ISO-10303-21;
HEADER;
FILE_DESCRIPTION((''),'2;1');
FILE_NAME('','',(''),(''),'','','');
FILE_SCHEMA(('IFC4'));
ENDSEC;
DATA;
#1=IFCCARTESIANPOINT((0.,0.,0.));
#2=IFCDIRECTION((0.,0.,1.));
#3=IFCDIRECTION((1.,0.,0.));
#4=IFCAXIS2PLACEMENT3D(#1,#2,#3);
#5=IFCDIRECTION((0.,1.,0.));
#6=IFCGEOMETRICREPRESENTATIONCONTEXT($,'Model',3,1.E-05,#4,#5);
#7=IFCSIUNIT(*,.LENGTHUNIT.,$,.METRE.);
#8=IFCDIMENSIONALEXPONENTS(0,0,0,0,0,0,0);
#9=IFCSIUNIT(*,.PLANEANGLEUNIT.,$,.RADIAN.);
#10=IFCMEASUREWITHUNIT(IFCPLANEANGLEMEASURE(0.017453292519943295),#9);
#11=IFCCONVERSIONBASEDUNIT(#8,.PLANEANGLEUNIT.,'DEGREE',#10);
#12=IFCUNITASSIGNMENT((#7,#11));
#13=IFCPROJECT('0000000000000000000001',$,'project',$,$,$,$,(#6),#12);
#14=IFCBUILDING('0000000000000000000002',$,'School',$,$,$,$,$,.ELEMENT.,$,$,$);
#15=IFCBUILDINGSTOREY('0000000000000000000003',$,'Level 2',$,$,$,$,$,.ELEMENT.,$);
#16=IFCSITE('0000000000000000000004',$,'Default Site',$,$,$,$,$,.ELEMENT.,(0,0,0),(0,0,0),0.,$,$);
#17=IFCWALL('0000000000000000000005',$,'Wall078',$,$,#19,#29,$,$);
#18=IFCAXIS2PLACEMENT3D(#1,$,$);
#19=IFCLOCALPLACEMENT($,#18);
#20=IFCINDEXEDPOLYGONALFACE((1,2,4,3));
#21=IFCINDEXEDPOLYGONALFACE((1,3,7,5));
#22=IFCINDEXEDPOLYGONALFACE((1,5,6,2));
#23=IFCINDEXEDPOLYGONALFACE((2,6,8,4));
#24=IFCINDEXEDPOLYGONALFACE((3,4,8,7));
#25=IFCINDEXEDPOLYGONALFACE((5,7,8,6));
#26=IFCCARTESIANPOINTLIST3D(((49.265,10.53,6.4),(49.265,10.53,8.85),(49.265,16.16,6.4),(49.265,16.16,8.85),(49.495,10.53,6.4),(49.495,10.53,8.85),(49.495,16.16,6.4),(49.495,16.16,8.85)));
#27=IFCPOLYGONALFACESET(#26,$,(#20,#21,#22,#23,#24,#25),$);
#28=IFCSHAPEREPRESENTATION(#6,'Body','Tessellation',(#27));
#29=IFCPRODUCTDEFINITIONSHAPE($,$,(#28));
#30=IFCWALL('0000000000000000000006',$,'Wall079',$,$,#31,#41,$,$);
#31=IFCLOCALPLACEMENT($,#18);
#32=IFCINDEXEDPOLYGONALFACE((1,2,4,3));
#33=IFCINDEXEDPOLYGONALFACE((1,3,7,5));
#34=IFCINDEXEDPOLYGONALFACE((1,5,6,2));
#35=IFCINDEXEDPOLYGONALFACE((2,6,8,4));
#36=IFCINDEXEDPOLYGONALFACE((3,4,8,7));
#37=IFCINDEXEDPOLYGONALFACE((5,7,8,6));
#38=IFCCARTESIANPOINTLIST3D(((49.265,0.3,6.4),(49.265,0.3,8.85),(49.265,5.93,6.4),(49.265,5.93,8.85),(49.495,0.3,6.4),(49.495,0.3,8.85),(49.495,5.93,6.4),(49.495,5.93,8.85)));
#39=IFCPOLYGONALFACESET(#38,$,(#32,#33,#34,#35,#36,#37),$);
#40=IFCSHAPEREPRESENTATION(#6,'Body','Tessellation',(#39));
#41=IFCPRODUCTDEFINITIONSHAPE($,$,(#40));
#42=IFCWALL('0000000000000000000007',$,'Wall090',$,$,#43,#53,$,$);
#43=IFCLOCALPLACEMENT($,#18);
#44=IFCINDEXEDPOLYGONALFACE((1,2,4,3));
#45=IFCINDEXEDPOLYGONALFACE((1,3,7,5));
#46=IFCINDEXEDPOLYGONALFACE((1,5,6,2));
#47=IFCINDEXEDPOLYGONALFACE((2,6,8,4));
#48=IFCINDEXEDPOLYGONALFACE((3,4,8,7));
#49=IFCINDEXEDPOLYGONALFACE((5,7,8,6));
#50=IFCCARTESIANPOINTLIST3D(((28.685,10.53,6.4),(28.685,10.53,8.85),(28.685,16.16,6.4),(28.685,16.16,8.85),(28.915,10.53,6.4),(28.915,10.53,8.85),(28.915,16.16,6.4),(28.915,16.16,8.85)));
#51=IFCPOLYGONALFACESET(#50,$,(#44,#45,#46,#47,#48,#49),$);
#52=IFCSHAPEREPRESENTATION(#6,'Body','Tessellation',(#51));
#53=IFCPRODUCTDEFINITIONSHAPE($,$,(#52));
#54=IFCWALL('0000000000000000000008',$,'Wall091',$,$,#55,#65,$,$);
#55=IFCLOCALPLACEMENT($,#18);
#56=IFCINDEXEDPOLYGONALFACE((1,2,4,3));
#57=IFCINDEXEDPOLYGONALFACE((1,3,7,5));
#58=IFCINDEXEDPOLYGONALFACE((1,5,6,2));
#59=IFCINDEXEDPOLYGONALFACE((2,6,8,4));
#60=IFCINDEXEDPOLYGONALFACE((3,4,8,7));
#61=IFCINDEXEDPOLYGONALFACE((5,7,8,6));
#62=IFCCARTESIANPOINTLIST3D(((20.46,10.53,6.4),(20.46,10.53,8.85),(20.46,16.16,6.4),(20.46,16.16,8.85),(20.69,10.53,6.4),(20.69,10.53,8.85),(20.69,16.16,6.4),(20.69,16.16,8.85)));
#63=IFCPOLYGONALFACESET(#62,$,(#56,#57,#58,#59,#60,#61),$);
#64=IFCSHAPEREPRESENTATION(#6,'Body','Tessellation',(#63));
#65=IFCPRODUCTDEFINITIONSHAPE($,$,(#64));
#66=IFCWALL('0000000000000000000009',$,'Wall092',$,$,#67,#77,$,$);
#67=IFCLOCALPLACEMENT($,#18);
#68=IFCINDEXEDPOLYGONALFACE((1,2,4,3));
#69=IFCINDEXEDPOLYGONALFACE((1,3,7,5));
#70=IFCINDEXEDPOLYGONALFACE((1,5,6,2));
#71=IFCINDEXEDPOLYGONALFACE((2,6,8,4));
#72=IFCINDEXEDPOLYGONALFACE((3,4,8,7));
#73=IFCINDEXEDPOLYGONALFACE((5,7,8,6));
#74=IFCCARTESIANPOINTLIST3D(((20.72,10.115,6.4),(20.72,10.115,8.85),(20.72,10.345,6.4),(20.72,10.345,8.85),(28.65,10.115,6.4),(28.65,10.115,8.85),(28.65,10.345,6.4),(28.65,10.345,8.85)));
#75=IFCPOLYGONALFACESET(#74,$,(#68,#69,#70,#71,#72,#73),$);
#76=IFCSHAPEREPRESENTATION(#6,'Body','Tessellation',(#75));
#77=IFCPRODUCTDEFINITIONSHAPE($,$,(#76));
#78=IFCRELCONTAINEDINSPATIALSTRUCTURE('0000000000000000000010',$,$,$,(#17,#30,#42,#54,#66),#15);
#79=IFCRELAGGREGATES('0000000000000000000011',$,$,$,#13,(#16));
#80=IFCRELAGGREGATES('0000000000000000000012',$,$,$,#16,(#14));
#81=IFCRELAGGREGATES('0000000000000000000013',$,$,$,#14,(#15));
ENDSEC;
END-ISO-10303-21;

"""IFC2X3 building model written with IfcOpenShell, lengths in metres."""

from ifc_helpers import new_model, entity, si_unit, converted_unit, direction, frame, frame_2d, origin_with_axes, place, context, project, spatial, rectangle, extrude, element, save


model = new_model("IFC2X3")

# Units and contexts
model_context = context("Model", 3, precision=1e-05, world=origin_with_axes(), true_north=direction((0.0, 1.0, 0.0)))
ifc_project = project(units=[si_unit("LENGTHUNIT", "METRE"), converted_unit("PLANEANGLEUNIT", "DEGREE", entity("IfcPlaneAngleMeasure", 0.017453292519943295), si_unit("PLANEANGLEUNIT", "RADIAN"), dimensions=[0, 0, 0, 0, 0, 0, 0])], contexts=[model_context])

# Site, building, storey
site = spatial("IfcSite", under=ifc_project, Name="Default Site", CompositionType="ELEMENT", RefLatitude=(0, 0, 0), RefLongitude=(0, 0, 0), RefElevation=0.0)
building = spatial("IfcBuilding", under=site, Name="School", CompositionType="ELEMENT")
storey = spatial("IfcBuildingStorey", under=building, Name="Level 2", CompositionType="ELEMENT")

# Shared definitions
placement = place(None, origin_with_axes())

# Walls
element("IfcWall", 1, at=placement, inside=storey, Name="Wall078", context=model_context, shape_type="SweptSolid", body=[
    extrude(rectangle(XDim=5.63, YDim=0.23, at=frame_2d((0.0, 0.0), x_axis=(0.0, 1.0, 0.0))), frame((49.38, 13.345, 6.4), z_axis=(0.0, 0.0, 1.0), x_axis=(1.0, 0.0, 0.0)), (0.0, 0.0, 1.0), 2.45),
])
element("IfcWall", 2, at=placement, inside=storey, Name="Wall079", context=model_context, shape_type="SweptSolid", body=[
    extrude(rectangle(XDim=5.63, YDim=0.23, at=frame_2d((0.0, 0.0), x_axis=(0.0, 1.0, 0.0))), frame((49.38, 3.115, 6.4), z_axis=(0.0, 0.0, 1.0), x_axis=(1.0, 0.0, 0.0)), (0.0, 0.0, 1.0), 2.45),
])
element("IfcWall", 3, at=placement, inside=storey, Name="Wall090", context=model_context, shape_type="SweptSolid", body=[
    extrude(rectangle(XDim=5.63, YDim=0.23, at=frame_2d((0.0, 0.0), x_axis=(0.0, 1.0, 0.0))), frame((28.8, 13.345, 6.4), z_axis=(0.0, 0.0, 1.0), x_axis=(1.0, 0.0, 0.0)), (0.0, 0.0, 1.0), 2.45),
])
element("IfcWall", 4, at=placement, inside=storey, Name="Wall091", context=model_context, shape_type="SweptSolid", body=[
    extrude(rectangle(XDim=5.63, YDim=0.23, at=frame_2d((0.0, 0.0), x_axis=(0.0, 1.0, 0.0))), frame((20.575, 13.345, 6.4), z_axis=(0.0, 0.0, 1.0), x_axis=(1.0, 0.0, 0.0)), (0.0, 0.0, 1.0), 2.45),
])
element("IfcWall", 5, at=placement, inside=storey, Name="Wall092", context=model_context, shape_type="SweptSolid", body=[
    extrude(rectangle(XDim=7.93, YDim=0.23, at=frame_2d((0.0, 0.0), x_axis=(1.0, 0.0, 0.0))), frame((24.685, 10.23, 6.4), z_axis=(0.0, 0.0, 1.0), x_axis=(1.0, 0.0, 0.0)), (0.0, 0.0, 1.0), 2.45),
])

save(model, "model.ifc")
